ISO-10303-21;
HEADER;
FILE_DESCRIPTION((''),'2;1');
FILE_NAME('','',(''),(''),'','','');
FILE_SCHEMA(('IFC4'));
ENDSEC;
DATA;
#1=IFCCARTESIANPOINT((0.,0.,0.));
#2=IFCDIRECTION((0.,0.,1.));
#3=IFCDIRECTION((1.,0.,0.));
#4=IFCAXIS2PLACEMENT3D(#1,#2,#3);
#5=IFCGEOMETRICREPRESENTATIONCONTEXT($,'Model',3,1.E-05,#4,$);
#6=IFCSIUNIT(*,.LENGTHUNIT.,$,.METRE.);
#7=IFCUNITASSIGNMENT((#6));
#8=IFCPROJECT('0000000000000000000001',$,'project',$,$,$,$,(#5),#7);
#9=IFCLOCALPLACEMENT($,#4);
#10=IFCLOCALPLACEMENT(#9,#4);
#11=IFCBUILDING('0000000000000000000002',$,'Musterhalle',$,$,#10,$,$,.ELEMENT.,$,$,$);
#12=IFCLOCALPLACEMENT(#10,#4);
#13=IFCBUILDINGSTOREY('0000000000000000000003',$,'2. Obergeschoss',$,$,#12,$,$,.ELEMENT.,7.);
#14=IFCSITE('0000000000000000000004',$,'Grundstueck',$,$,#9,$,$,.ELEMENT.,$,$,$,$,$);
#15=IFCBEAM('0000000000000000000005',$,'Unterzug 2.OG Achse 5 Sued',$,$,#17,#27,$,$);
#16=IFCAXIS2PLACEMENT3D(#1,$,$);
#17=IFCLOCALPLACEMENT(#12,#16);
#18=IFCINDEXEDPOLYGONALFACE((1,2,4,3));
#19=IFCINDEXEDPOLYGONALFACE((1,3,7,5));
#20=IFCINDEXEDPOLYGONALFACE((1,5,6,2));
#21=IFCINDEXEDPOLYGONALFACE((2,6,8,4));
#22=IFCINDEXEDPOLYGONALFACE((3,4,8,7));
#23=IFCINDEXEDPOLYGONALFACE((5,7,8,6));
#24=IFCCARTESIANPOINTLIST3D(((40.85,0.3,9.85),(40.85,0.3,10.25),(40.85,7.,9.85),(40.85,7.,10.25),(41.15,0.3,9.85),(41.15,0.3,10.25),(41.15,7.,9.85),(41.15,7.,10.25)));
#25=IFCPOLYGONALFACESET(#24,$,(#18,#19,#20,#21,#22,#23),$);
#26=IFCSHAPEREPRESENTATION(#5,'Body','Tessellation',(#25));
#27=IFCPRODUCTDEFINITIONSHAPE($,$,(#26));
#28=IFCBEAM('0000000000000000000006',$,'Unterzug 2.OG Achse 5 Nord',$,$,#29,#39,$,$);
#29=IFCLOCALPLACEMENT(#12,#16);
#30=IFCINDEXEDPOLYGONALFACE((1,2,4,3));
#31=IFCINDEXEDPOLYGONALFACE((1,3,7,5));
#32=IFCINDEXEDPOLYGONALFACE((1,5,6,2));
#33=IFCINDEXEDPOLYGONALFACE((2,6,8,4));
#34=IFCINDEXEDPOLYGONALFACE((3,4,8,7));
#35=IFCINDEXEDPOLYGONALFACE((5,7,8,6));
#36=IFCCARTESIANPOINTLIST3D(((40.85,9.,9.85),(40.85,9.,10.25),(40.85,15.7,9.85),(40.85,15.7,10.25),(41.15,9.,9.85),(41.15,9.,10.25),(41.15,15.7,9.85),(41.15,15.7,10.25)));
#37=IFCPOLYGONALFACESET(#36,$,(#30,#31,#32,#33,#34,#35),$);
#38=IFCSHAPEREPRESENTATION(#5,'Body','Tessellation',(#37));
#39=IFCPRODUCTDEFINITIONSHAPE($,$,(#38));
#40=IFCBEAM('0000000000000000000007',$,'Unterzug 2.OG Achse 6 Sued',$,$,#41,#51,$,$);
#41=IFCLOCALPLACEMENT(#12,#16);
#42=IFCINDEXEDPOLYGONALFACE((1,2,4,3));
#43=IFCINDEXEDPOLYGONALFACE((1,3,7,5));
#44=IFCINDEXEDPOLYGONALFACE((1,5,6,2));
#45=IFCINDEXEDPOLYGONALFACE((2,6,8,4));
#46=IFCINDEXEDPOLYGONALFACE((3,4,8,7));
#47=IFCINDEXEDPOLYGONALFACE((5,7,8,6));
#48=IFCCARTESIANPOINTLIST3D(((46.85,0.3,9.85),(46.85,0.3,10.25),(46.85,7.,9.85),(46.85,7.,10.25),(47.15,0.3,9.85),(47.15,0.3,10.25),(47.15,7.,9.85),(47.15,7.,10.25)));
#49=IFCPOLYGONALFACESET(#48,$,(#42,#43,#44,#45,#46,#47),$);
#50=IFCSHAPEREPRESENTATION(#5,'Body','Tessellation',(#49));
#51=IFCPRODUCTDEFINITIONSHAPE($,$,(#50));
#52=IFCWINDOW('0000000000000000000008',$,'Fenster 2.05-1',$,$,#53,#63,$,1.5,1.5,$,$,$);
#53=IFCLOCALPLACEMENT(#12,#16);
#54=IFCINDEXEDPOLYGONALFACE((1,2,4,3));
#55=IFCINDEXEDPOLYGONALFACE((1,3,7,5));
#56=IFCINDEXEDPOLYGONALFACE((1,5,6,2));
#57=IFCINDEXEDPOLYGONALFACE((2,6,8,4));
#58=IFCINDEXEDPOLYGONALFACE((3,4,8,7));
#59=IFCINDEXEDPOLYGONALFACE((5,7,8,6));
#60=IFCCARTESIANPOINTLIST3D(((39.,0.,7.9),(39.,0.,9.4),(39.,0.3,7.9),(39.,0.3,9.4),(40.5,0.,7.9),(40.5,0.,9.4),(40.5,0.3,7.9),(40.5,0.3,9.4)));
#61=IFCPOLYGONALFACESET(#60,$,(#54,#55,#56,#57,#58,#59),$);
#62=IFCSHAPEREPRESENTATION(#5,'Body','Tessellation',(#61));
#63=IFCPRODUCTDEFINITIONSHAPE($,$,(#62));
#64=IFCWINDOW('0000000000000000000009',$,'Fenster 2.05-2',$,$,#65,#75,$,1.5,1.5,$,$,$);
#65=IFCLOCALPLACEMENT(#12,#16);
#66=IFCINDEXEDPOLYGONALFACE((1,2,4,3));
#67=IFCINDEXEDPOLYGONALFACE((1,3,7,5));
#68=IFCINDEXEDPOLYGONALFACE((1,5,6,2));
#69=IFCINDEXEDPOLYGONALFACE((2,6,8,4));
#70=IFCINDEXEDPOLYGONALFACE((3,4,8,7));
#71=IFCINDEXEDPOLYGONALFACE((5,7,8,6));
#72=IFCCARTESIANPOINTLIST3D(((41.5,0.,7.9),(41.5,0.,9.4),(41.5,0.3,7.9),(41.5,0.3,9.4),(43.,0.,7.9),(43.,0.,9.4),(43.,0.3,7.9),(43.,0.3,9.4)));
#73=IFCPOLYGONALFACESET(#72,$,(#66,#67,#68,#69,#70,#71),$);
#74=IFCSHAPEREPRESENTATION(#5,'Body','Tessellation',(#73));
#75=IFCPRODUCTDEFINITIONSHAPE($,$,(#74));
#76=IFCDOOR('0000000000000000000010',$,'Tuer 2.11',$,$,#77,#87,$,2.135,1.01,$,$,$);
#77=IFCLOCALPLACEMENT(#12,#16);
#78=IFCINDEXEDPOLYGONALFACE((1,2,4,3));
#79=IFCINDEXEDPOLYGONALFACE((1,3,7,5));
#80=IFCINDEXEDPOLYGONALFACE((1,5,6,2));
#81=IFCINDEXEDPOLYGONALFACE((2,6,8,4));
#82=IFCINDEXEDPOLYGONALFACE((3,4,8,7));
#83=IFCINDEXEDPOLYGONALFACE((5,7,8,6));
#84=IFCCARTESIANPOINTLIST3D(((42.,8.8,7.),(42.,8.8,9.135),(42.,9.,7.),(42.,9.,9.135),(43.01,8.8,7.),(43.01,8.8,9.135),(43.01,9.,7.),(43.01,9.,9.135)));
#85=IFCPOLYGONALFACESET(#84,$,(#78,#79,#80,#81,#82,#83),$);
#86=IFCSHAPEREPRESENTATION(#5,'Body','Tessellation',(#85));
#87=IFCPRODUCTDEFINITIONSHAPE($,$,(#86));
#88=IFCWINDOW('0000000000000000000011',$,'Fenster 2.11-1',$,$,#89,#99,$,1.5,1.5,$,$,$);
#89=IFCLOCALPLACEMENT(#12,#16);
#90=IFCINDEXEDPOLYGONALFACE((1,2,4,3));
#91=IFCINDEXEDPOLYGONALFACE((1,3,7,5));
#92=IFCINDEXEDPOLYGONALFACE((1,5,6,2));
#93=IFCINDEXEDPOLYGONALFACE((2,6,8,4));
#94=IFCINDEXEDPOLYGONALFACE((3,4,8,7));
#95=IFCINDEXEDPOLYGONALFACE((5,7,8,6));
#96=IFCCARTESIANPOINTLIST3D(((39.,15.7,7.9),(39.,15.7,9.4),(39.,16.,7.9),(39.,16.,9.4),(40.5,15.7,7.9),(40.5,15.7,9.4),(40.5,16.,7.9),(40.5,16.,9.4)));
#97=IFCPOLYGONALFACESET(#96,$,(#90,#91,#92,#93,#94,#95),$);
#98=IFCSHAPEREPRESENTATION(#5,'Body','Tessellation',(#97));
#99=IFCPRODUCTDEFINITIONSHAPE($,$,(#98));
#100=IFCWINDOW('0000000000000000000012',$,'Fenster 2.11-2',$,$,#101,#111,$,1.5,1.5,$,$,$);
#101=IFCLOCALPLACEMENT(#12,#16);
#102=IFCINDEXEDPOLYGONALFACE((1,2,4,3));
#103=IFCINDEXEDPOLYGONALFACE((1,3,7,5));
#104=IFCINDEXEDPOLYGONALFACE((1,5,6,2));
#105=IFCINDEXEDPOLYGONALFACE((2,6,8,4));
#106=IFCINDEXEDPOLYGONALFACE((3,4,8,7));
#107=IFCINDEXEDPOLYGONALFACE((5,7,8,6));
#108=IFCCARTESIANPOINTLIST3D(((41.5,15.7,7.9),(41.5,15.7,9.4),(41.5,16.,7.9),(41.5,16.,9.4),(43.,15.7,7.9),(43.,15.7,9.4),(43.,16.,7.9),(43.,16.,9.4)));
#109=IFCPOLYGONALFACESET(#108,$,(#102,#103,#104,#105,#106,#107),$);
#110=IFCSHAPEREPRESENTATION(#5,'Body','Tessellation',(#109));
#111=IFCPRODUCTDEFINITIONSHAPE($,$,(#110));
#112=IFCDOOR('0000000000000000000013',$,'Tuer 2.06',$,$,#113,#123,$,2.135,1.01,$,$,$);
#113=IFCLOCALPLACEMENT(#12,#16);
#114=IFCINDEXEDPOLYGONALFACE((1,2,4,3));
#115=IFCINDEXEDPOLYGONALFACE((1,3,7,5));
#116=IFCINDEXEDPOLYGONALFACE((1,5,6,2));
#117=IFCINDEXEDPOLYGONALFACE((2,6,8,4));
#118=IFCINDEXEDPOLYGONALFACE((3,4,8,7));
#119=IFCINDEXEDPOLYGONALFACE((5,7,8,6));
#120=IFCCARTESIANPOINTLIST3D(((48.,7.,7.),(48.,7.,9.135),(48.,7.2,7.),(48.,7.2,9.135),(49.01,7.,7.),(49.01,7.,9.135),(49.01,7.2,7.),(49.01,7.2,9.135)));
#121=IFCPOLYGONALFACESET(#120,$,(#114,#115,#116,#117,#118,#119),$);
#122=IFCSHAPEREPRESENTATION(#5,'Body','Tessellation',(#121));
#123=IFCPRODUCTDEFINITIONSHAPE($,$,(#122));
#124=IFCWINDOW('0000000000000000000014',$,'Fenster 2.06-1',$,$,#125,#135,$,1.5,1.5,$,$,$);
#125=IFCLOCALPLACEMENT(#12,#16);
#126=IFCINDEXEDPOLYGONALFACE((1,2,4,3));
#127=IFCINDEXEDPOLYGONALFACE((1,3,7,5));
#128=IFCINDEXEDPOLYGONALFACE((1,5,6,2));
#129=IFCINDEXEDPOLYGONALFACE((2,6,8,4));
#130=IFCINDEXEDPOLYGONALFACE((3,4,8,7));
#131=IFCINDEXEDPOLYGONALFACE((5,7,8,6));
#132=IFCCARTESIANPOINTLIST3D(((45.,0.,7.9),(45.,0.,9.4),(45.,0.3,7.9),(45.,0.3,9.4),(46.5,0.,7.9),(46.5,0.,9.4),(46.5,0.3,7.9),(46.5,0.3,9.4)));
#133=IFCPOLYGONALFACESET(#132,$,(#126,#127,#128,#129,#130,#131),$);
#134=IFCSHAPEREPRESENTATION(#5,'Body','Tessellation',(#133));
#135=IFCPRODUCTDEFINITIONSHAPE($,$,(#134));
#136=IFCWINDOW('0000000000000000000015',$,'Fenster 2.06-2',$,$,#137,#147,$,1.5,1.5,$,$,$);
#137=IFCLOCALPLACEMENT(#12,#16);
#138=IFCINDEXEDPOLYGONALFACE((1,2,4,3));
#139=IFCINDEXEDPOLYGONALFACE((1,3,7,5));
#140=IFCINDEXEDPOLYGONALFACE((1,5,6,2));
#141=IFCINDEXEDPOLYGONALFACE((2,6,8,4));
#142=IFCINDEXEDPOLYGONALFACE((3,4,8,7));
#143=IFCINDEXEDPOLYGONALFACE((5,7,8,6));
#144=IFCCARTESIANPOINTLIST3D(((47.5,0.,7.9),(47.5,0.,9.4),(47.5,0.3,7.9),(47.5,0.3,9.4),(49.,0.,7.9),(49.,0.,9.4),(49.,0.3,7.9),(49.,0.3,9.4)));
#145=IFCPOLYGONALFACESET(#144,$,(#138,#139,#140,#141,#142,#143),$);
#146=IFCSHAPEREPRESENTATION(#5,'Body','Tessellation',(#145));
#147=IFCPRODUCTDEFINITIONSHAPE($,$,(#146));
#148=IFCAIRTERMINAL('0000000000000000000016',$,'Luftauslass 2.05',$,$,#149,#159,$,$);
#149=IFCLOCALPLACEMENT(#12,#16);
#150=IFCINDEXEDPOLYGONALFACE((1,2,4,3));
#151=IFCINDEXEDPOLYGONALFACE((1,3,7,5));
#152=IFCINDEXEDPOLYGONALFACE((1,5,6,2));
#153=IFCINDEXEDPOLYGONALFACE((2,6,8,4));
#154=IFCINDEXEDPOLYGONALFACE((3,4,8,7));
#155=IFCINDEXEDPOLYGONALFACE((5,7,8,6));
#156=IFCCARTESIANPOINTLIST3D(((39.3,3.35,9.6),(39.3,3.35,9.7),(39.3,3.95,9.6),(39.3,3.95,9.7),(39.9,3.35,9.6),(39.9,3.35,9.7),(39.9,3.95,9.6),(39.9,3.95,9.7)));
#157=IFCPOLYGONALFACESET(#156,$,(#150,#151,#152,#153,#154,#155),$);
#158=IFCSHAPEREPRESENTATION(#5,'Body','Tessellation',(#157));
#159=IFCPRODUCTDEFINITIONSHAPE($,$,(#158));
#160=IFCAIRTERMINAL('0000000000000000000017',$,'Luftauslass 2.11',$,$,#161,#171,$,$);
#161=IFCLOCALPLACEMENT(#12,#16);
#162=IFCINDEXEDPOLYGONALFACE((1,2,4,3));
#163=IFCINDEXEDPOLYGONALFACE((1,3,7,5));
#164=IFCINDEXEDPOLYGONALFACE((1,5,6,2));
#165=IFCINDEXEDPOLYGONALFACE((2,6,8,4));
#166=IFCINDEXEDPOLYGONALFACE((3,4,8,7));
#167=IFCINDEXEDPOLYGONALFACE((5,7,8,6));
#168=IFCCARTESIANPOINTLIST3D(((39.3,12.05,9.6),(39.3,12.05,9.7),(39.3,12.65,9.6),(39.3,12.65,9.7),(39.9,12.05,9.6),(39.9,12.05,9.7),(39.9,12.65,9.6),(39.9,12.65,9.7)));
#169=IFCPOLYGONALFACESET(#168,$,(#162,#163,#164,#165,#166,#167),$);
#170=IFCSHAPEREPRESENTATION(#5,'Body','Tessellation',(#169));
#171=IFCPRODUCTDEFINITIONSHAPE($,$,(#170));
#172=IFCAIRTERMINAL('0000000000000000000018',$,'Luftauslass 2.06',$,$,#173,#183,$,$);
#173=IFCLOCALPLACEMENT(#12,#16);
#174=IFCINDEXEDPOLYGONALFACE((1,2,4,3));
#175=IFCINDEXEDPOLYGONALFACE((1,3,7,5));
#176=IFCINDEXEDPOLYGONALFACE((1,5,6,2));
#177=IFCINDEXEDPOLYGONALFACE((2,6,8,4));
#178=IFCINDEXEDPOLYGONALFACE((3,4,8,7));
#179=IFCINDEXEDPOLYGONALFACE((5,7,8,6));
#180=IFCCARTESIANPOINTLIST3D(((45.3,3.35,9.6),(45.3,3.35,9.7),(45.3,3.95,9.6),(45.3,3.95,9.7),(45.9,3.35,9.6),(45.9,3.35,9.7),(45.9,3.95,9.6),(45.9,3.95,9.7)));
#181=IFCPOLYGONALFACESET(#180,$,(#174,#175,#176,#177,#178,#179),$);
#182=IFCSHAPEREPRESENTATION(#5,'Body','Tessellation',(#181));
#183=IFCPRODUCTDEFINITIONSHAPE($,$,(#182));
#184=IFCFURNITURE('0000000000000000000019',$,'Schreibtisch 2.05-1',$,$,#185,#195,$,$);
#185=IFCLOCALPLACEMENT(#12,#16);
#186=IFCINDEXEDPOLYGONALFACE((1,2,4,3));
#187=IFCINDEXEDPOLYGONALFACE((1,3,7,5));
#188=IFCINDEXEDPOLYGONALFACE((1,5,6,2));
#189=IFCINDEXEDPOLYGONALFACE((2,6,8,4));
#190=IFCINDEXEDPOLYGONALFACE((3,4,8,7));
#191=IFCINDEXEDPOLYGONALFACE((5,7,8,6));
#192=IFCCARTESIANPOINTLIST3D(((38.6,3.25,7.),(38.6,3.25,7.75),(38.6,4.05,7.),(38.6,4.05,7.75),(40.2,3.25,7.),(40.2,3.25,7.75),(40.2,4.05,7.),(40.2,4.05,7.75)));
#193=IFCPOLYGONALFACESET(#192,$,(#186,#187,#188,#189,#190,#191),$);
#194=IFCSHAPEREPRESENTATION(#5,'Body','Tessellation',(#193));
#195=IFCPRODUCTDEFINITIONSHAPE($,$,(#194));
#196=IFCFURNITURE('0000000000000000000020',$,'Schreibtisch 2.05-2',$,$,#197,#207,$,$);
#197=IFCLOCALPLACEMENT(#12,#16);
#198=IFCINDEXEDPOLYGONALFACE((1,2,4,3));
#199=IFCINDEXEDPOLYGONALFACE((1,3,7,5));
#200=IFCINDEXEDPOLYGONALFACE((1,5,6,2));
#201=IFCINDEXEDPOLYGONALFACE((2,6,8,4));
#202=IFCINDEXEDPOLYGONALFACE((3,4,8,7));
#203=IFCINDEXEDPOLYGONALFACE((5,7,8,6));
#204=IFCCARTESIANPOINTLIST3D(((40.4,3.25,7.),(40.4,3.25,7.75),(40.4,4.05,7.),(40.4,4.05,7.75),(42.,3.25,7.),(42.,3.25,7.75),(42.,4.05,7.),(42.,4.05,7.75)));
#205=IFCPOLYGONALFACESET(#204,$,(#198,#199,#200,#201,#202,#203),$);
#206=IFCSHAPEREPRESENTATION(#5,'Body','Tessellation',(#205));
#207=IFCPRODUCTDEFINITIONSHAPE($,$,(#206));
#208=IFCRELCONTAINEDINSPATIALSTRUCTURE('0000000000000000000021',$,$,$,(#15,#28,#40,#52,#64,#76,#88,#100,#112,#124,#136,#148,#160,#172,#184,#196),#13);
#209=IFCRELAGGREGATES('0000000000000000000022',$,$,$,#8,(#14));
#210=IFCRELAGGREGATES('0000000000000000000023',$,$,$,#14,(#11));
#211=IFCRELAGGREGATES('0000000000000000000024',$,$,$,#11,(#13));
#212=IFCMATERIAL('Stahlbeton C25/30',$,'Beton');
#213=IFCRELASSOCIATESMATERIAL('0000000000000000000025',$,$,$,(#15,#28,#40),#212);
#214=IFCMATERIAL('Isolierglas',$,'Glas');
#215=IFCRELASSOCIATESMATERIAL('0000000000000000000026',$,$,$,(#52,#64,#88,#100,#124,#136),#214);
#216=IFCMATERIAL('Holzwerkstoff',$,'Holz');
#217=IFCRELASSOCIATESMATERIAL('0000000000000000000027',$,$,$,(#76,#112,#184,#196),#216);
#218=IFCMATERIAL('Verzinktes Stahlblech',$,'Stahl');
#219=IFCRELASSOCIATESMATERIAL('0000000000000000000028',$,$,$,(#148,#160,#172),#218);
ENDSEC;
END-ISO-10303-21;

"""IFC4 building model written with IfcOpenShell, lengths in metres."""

from ifc_helpers import new_model, si_unit, frame, origin_with_axes, origin_2d, place, context, project, spatial, rectangle, extrude, material, element, save


model = new_model("IFC4")

# Units and contexts
model_context = context("Model", 3, precision=1e-05, world=origin_with_axes())
ifc_project = project(units=[si_unit("LENGTHUNIT", "METRE")], contexts=[model_context])

# Site, building, storey
site_placement = place(None, origin_with_axes())
site = spatial("IfcSite", under=ifc_project, at=site_placement, Name="Grundstueck", CompositionType="ELEMENT")
building_placement = place(site_placement, origin_with_axes())
building = spatial("IfcBuilding", under=site, at=building_placement, Name="Musterhalle", CompositionType="ELEMENT")
storey_placement = place(building_placement, origin_with_axes())
storey = spatial("IfcBuildingStorey", under=building, at=storey_placement, Name="2. Obergeschoss", CompositionType="ELEMENT", Elevation=7.0)

# Beams
ifc_material_1 = material(Name="Stahlbeton C25/30", Category="Beton")
placement = place(storey_placement, origin_with_axes())
element("IfcBeam", 1, at=placement, inside=storey, material=ifc_material_1, Name="Unterzug 2.OG Achse 5 Sued", context=model_context, shape_type="SweptSolid", body=[
    extrude(rectangle(XDim=0.3, YDim=6.7, at=origin_2d()), frame((41.0, 3.65, 9.85), z_axis=(0.0, 0.0, 1.0), x_axis=(1.0, 0.0, 0.0)), (0.0, 0.0, 1.0), 0.4),
])
element("IfcBeam", 2, at=placement, inside=storey, material=ifc_material_1, Name="Unterzug 2.OG Achse 5 Nord", context=model_context, shape_type="SweptSolid", body=[
    extrude(rectangle(XDim=0.3, YDim=6.7, at=origin_2d()), frame((41.0, 12.35, 9.85), z_axis=(0.0, 0.0, 1.0), x_axis=(1.0, 0.0, 0.0)), (0.0, 0.0, 1.0), 0.4),
])
element("IfcBeam", 3, at=placement, inside=storey, material=ifc_material_1, Name="Unterzug 2.OG Achse 6 Sued", context=model_context, shape_type="SweptSolid", body=[
    extrude(rectangle(XDim=0.3, YDim=6.7, at=origin_2d()), frame((47.0, 3.65, 9.85), z_axis=(0.0, 0.0, 1.0), x_axis=(1.0, 0.0, 0.0)), (0.0, 0.0, 1.0), 0.4),
])

# Windows
ifc_material_2 = material(Name="Isolierglas", Category="Glas")
element("IfcWindow", 4, at=placement, inside=storey, material=ifc_material_2, Name="Fenster 2.05-1", OverallHeight=1.5, OverallWidth=1.5, context=model_context, shape_type="SweptSolid", body=[
    extrude(rectangle(XDim=1.5, YDim=0.3, at=origin_2d()), frame((39.75, 0.15, 7.9), z_axis=(0.0, 0.0, 1.0), x_axis=(1.0, 0.0, 0.0)), (0.0, 0.0, 1.0), 1.5),
])
element("IfcWindow", 5, at=placement, inside=storey, material=ifc_material_2, Name="Fenster 2.05-2", OverallHeight=1.5, OverallWidth=1.5, context=model_context, shape_type="SweptSolid", body=[
    extrude(rectangle(XDim=1.5, YDim=0.3, at=origin_2d()), frame((42.25, 0.15, 7.9), z_axis=(0.0, 0.0, 1.0), x_axis=(1.0, 0.0, 0.0)), (0.0, 0.0, 1.0), 1.5),
])

# Door
ifc_material_3 = material(Name="Holzwerkstoff", Category="Holz")
element("IfcDoor", 6, at=placement, inside=storey, material=ifc_material_3, Name="Tuer 2.11", OverallHeight=2.135, OverallWidth=1.01, context=model_context, shape_type="SweptSolid", body=[
    extrude(rectangle(XDim=1.01, YDim=0.2, at=origin_2d()), frame((42.505, 8.9, 7.0), z_axis=(0.0, 0.0, 1.0), x_axis=(1.0, 0.0, 0.0)), (0.0, 0.0, 1.0), 2.135),
])

# Windows
element("IfcWindow", 7, at=placement, inside=storey, material=ifc_material_2, Name="Fenster 2.11-1", OverallHeight=1.5, OverallWidth=1.5, context=model_context, shape_type="SweptSolid", body=[
    extrude(rectangle(XDim=1.5, YDim=0.3, at=origin_2d()), frame((39.75, 15.85, 7.9), z_axis=(0.0, 0.0, 1.0), x_axis=(1.0, 0.0, 0.0)), (0.0, 0.0, 1.0), 1.5),
])
element("IfcWindow", 8, at=placement, inside=storey, material=ifc_material_2, Name="Fenster 2.11-2", OverallHeight=1.5, OverallWidth=1.5, context=model_context, shape_type="SweptSolid", body=[
    extrude(rectangle(XDim=1.5, YDim=0.3, at=origin_2d()), frame((42.25, 15.85, 7.9), z_axis=(0.0, 0.0, 1.0), x_axis=(1.0, 0.0, 0.0)), (0.0, 0.0, 1.0), 1.5),
])

# Door
element("IfcDoor", 9, at=placement, inside=storey, material=ifc_material_3, Name="Tuer 2.06", OverallHeight=2.135, OverallWidth=1.01, context=model_context, shape_type="SweptSolid", body=[
    extrude(rectangle(XDim=1.01, YDim=0.2, at=origin_2d()), frame((48.505, 7.1, 7.0), z_axis=(0.0, 0.0, 1.0), x_axis=(1.0, 0.0, 0.0)), (0.0, 0.0, 1.0), 2.135),
])

# Windows
element("IfcWindow", 10, at=placement, inside=storey, material=ifc_material_2, Name="Fenster 2.06-1", OverallHeight=1.5, OverallWidth=1.5, context=model_context, shape_type="SweptSolid", body=[
    extrude(rectangle(XDim=1.5, YDim=0.3, at=origin_2d()), frame((45.75, 0.15, 7.9), z_axis=(0.0, 0.0, 1.0), x_axis=(1.0, 0.0, 0.0)), (0.0, 0.0, 1.0), 1.5),
])
element("IfcWindow", 11, at=placement, inside=storey, material=ifc_material_2, Name="Fenster 2.06-2", OverallHeight=1.5, OverallWidth=1.5, context=model_context, shape_type="SweptSolid", body=[
    extrude(rectangle(XDim=1.5, YDim=0.3, at=origin_2d()), frame((48.25, 0.15, 7.9), z_axis=(0.0, 0.0, 1.0), x_axis=(1.0, 0.0, 0.0)), (0.0, 0.0, 1.0), 1.5),
])

# Air terminals
ifc_material_4 = material(Name="Verzinktes Stahlblech", Category="Stahl")
element("IfcAirTerminal", 12, at=placement, inside=storey, material=ifc_material_4, Name="Luftauslass 2.05", context=model_context, shape_type="SweptSolid", body=[
    extrude(rectangle(XDim=0.6, YDim=0.6, at=origin_2d()), frame((39.6, 3.65, 9.6), z_axis=(0.0, 0.0, 1.0), x_axis=(1.0, 0.0, 0.0)), (0.0, 0.0, 1.0), 0.1),
])
element("IfcAirTerminal", 13, at=placement, inside=storey, material=ifc_material_4, Name="Luftauslass 2.11", context=model_context, shape_type="SweptSolid", body=[
    extrude(rectangle(XDim=0.6, YDim=0.6, at=origin_2d()), frame((39.6, 12.35, 9.6), z_axis=(0.0, 0.0, 1.0), x_axis=(1.0, 0.0, 0.0)), (0.0, 0.0, 1.0), 0.1),
])
element("IfcAirTerminal", 14, at=placement, inside=storey, material=ifc_material_4, Name="Luftauslass 2.06", context=model_context, shape_type="SweptSolid", body=[
    extrude(rectangle(XDim=0.6, YDim=0.6, at=origin_2d()), frame((45.6, 3.65, 9.6), z_axis=(0.0, 0.0, 1.0), x_axis=(1.0, 0.0, 0.0)), (0.0, 0.0, 1.0), 0.1),
])

# Furniture
element("IfcFurniture", 15, at=placement, inside=storey, material=ifc_material_3, Name="Schreibtisch 2.05-1", context=model_context, shape_type="SweptSolid", body=[
    extrude(rectangle(XDim=1.6, YDim=0.8, at=origin_2d()), frame((39.4, 3.65, 7.0), z_axis=(0.0, 0.0, 1.0), x_axis=(1.0, 0.0, 0.0)), (0.0, 0.0, 1.0), 0.75),
])
element("IfcFurniture", 16, at=placement, inside=storey, material=ifc_material_3, Name="Schreibtisch 2.05-2", context=model_context, shape_type="SweptSolid", body=[
    extrude(rectangle(XDim=1.6, YDim=0.8, at=origin_2d()), frame((41.2, 3.65, 7.0), z_axis=(0.0, 0.0, 1.0), x_axis=(1.0, 0.0, 0.0)), (0.0, 0.0, 1.0), 0.75),
])

save(model, "model.ifc")
